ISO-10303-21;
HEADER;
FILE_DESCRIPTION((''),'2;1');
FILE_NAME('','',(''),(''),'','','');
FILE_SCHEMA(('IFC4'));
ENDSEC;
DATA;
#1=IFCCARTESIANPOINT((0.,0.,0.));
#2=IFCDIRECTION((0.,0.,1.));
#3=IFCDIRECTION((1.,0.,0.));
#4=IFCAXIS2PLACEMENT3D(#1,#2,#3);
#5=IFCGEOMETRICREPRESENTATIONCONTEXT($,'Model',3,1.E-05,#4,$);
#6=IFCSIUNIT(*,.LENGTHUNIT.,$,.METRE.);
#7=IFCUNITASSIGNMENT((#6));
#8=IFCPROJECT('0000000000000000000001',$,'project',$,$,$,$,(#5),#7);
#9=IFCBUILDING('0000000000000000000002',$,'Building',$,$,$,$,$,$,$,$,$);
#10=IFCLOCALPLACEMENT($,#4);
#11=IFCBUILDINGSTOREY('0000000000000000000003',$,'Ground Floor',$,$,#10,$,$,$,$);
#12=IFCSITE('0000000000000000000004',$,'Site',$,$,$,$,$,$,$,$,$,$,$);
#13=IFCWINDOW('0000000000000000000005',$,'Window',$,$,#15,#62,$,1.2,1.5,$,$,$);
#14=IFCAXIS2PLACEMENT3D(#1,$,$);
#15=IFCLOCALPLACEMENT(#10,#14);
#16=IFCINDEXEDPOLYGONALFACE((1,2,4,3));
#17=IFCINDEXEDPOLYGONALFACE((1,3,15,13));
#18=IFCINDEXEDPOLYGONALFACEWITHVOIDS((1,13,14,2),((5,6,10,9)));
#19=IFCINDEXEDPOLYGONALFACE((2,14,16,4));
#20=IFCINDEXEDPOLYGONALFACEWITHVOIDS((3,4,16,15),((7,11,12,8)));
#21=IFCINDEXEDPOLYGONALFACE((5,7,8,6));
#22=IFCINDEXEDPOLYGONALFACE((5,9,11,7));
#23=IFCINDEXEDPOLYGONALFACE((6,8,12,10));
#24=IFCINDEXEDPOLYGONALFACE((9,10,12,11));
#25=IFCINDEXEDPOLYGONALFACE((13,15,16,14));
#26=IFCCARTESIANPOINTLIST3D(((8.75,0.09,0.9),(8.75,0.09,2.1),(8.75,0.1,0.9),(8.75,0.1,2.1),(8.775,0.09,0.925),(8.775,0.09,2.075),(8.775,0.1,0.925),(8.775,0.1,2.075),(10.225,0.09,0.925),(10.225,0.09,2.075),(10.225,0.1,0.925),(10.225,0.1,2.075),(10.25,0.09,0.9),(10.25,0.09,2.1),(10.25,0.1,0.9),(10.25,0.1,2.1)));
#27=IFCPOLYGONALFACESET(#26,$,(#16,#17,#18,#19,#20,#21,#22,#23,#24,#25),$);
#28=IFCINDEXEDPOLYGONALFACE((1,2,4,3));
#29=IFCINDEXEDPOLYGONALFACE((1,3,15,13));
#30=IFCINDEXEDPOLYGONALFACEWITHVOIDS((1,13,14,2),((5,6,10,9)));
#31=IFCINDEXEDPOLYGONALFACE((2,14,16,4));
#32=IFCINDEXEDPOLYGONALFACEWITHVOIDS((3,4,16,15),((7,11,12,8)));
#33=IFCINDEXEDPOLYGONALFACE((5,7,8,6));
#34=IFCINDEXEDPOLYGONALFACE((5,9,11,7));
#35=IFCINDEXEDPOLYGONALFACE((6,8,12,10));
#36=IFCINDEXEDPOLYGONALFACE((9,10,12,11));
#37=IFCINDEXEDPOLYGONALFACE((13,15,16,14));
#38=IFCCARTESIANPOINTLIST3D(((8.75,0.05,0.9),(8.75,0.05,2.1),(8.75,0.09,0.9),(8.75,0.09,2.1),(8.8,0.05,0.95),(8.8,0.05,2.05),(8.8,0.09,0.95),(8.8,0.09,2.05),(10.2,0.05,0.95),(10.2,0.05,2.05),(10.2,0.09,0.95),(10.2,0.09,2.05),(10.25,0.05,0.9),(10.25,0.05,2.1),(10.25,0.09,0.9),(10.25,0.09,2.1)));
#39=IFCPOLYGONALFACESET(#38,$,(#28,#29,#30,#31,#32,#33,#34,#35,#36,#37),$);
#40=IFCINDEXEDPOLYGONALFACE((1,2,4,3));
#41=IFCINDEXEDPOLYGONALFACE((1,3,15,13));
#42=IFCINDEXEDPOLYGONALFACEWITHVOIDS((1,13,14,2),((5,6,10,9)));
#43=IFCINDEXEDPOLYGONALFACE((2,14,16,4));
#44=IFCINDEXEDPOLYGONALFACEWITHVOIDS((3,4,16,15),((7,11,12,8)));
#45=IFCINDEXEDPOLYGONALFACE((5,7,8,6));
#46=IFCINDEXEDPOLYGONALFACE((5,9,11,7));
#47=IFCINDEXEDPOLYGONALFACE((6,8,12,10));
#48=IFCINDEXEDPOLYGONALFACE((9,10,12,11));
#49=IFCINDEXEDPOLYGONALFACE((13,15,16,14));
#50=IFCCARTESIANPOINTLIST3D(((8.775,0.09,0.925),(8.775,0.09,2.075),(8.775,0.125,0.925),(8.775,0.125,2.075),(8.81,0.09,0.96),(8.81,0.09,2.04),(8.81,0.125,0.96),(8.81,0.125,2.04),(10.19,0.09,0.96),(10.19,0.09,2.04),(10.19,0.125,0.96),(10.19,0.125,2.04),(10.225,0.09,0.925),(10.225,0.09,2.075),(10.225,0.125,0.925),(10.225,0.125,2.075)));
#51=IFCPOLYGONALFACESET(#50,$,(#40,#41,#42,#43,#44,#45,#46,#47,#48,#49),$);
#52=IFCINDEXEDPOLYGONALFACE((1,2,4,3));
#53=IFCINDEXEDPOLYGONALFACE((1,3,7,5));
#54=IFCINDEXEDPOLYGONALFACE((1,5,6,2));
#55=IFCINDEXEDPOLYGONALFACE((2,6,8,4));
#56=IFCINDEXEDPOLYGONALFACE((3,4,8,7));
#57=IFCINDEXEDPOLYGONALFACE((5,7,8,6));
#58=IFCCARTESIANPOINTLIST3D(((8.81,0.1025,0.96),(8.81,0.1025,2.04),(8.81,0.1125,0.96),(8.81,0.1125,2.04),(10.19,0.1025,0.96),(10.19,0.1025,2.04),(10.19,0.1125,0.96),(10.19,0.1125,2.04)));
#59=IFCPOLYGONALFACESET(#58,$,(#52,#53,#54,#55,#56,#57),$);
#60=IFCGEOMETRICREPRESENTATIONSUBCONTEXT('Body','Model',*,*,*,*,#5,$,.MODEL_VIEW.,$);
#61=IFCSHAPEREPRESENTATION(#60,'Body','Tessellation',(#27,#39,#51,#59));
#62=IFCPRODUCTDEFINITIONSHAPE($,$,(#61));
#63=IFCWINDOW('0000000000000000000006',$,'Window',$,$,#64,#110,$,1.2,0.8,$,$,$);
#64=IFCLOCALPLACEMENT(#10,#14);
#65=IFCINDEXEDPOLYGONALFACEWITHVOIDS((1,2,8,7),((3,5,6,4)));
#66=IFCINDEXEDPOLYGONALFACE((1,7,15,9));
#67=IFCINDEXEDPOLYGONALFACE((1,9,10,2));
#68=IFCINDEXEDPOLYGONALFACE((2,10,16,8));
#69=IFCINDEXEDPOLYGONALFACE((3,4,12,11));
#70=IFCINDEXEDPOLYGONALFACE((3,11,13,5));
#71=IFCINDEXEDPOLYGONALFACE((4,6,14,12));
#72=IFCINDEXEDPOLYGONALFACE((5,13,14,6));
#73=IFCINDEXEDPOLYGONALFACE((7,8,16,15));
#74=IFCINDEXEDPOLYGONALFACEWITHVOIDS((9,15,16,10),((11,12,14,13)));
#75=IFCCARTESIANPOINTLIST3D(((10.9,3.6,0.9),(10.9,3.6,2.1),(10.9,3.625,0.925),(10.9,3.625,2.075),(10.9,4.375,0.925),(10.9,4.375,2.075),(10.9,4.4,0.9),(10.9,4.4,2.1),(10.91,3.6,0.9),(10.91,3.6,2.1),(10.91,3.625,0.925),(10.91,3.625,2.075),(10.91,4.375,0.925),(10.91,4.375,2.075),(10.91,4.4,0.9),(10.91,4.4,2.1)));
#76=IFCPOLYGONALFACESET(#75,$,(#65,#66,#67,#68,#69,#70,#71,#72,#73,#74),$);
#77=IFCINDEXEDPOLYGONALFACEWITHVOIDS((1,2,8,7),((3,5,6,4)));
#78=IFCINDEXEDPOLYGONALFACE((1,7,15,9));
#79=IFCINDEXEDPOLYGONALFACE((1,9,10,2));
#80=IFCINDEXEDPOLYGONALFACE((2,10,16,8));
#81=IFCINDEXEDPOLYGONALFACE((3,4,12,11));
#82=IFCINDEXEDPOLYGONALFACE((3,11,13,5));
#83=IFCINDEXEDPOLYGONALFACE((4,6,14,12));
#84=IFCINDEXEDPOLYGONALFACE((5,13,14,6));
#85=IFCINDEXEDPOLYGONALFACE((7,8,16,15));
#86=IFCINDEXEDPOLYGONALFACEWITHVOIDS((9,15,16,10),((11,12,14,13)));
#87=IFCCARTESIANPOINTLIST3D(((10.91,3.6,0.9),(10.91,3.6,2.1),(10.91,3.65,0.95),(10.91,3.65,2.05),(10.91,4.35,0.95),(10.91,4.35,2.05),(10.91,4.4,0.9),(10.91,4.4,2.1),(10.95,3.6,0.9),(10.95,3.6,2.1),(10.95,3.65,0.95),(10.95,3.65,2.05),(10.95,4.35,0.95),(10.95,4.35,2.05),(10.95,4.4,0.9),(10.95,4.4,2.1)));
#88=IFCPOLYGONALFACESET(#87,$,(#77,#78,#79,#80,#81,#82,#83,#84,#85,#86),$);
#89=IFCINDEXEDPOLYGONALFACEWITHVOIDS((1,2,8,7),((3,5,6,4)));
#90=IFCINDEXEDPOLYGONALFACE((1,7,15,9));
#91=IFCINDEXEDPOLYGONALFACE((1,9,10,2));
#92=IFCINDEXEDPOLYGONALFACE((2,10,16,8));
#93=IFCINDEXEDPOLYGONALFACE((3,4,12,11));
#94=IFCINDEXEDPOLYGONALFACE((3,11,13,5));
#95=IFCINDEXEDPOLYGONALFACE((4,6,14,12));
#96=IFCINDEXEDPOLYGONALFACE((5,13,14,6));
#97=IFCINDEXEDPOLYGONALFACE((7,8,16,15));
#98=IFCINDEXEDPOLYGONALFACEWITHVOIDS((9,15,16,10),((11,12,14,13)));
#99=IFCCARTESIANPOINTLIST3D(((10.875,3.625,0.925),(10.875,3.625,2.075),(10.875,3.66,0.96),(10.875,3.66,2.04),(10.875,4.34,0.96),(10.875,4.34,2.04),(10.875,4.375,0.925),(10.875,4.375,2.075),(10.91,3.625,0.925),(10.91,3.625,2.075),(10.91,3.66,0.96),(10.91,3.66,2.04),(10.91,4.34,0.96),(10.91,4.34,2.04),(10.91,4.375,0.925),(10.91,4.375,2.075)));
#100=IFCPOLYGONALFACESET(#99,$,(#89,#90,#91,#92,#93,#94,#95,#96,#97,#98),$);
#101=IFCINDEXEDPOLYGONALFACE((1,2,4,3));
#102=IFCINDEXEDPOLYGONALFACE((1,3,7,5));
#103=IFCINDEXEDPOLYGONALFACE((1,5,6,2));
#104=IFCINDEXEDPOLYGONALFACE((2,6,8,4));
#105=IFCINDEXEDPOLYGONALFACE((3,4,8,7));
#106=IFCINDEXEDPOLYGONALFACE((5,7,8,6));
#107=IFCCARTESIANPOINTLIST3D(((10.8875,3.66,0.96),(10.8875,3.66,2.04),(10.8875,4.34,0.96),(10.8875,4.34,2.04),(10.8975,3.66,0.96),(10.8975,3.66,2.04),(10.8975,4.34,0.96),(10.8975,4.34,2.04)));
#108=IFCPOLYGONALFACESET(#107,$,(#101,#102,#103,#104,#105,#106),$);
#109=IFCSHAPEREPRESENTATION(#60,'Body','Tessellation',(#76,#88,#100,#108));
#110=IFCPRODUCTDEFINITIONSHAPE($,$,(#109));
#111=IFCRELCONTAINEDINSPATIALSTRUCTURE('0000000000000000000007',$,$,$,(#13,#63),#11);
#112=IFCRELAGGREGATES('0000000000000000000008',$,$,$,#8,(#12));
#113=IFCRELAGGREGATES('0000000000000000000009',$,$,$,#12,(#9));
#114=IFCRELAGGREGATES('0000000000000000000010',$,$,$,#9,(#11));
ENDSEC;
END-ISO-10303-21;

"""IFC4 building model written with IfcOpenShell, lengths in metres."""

from ifc_helpers import new_model, si_unit, frame, origin_with_axes, place, context, subcontext, project, spatial, line, indexed_curve, outline, extrude, element, save


model = new_model("IFC4")

# Units and contexts
model_context = context("Model", 3, precision=1e-05, world=origin_with_axes())
body_context = subcontext(model_context, "Body", "Model", "MODEL_VIEW")
ifc_project = project(units=[si_unit("LENGTHUNIT", "METRE")], contexts=[model_context])

# Site, building, storey
site = spatial("IfcSite", under=ifc_project, Name="Site")
building = spatial("IfcBuilding", under=site, Name="Building")
storey_placement = place(None, origin_with_axes())
storey = spatial("IfcBuildingStorey", under=building, at=storey_placement, Name="Ground Floor")

# Windows
window_1_placement = place(storey_placement, frame((8.75, 0.0, 0.9), z_axis=(0.0, 0.0, 1.0), x_axis=(1.0, 0.0, 0.0)))
element("IfcWindow", 1, at=window_1_placement, inside=storey, Name="Window", OverallHeight=1.2, OverallWidth=1.5, context=body_context, shape_type="SweptSolid", body=[
    extrude(outline(indexed_curve([(0.0, 0.0), (1.5, 0.0), (1.5, 1.2), (0.0, 1.2)], segments=[line(1, 2, 3, 4, 1)]), holes=[indexed_curve([(0.025, 0.025), (1.475, 0.025), (1.475, 1.175), (0.025, 1.175)], segments=[line(1, 2, 3, 4, 1)])]), frame((0.0, 0.09, 0.0), z_axis=(0.0, -1.0, 0.0), x_axis=(1.0, 0.0, 0.0)), (0.0, 0.0, -1.0), 0.01),
    extrude(outline(indexed_curve([(0.0, 0.0), (1.5, 0.0), (1.5, 1.2), (0.0, 1.2)], segments=[line(1, 2, 3, 4, 1)]), holes=[indexed_curve([(0.05, 0.05), (1.45, 0.05), (1.45, 1.15), (0.05, 1.15)], segments=[line(1, 2, 3, 4, 1)])]), frame((0.0, 0.05, 0.0), z_axis=(0.0, -1.0, 0.0), x_axis=(1.0, 0.0, 0.0)), (0.0, 0.0, -1.0), 0.04),
    extrude(outline(indexed_curve([(0.0, 0.0), (1.45, 0.0), (1.45, 1.15), (0.0, 1.15)], segments=[line(1, 2, 3, 4, 1)]), holes=[indexed_curve([(0.035, 0.035), (1.415, 0.035), (1.415, 1.115), (0.035, 1.115)], segments=[line(1, 2, 3, 4, 1)])]), frame((0.025, 0.09, 0.025), z_axis=(0.0, -1.0, 0.0), x_axis=(1.0, 0.0, 0.0)), (0.0, 0.0, -1.0), 0.035),
    extrude(outline(indexed_curve([(0.035, 0.035), (1.415, 0.035), (1.415, 1.115), (0.035, 1.115)], segments=[line(1, 2, 3, 4, 1)])), frame((0.025, 0.1025, 0.025), z_axis=(0.0, -1.0, 0.0), x_axis=(1.0, 0.0, 0.0)), (0.0, 0.0, -1.0), 0.01),
])
window_2_placement = place(storey_placement, frame((11.0, 3.6, 0.9), z_axis=(0.0, 0.0, 1.0), x_axis=(0.0, 1.0, 0.0)))
element("IfcWindow", 2, at=window_2_placement, inside=storey, Name="Window", OverallHeight=1.2, OverallWidth=0.8, context=body_context, shape_type="SweptSolid", body=[
    extrude(outline(indexed_curve([(0.0, 0.0), (0.8, 0.0), (0.8, 1.2), (0.0, 1.2)], segments=[line(1, 2, 3, 4, 1)]), holes=[indexed_curve([(0.025, 0.025), (0.775, 0.025), (0.775, 1.175), (0.025, 1.175)], segments=[line(1, 2, 3, 4, 1)])]), frame((0.0, 0.09, 0.0), z_axis=(0.0, -1.0, 0.0), x_axis=(1.0, 0.0, 0.0)), (0.0, 0.0, -1.0), 0.01),
    extrude(outline(indexed_curve([(0.0, 0.0), (0.8, 0.0), (0.8, 1.2), (0.0, 1.2)], segments=[line(1, 2, 3, 4, 1)]), holes=[indexed_curve([(0.05, 0.05), (0.75, 0.05), (0.75, 1.15), (0.05, 1.15)], segments=[line(1, 2, 3, 4, 1)])]), frame((0.0, 0.05, 0.0), z_axis=(0.0, -1.0, 0.0), x_axis=(1.0, 0.0, 0.0)), (0.0, 0.0, -1.0), 0.04),
    extrude(outline(indexed_curve([(0.0, 0.0), (0.75, 0.0), (0.75, 1.15), (0.0, 1.15)], segments=[line(1, 2, 3, 4, 1)]), holes=[indexed_curve([(0.035, 0.035), (0.715, 0.035), (0.715, 1.115), (0.035, 1.115)], segments=[line(1, 2, 3, 4, 1)])]), frame((0.025, 0.09, 0.025), z_axis=(0.0, -1.0, 0.0), x_axis=(1.0, 0.0, 0.0)), (0.0, 0.0, -1.0), 0.035),
    extrude(outline(indexed_curve([(0.035, 0.035), (0.715, 0.035), (0.715, 1.115), (0.035, 1.115)], segments=[line(1, 2, 3, 4, 1)])), frame((0.025, 0.1025, 0.025), z_axis=(0.0, -1.0, 0.0), x_axis=(1.0, 0.0, 0.0)), (0.0, 0.0, -1.0), 0.01),
])

save(model, "model.ifc")
